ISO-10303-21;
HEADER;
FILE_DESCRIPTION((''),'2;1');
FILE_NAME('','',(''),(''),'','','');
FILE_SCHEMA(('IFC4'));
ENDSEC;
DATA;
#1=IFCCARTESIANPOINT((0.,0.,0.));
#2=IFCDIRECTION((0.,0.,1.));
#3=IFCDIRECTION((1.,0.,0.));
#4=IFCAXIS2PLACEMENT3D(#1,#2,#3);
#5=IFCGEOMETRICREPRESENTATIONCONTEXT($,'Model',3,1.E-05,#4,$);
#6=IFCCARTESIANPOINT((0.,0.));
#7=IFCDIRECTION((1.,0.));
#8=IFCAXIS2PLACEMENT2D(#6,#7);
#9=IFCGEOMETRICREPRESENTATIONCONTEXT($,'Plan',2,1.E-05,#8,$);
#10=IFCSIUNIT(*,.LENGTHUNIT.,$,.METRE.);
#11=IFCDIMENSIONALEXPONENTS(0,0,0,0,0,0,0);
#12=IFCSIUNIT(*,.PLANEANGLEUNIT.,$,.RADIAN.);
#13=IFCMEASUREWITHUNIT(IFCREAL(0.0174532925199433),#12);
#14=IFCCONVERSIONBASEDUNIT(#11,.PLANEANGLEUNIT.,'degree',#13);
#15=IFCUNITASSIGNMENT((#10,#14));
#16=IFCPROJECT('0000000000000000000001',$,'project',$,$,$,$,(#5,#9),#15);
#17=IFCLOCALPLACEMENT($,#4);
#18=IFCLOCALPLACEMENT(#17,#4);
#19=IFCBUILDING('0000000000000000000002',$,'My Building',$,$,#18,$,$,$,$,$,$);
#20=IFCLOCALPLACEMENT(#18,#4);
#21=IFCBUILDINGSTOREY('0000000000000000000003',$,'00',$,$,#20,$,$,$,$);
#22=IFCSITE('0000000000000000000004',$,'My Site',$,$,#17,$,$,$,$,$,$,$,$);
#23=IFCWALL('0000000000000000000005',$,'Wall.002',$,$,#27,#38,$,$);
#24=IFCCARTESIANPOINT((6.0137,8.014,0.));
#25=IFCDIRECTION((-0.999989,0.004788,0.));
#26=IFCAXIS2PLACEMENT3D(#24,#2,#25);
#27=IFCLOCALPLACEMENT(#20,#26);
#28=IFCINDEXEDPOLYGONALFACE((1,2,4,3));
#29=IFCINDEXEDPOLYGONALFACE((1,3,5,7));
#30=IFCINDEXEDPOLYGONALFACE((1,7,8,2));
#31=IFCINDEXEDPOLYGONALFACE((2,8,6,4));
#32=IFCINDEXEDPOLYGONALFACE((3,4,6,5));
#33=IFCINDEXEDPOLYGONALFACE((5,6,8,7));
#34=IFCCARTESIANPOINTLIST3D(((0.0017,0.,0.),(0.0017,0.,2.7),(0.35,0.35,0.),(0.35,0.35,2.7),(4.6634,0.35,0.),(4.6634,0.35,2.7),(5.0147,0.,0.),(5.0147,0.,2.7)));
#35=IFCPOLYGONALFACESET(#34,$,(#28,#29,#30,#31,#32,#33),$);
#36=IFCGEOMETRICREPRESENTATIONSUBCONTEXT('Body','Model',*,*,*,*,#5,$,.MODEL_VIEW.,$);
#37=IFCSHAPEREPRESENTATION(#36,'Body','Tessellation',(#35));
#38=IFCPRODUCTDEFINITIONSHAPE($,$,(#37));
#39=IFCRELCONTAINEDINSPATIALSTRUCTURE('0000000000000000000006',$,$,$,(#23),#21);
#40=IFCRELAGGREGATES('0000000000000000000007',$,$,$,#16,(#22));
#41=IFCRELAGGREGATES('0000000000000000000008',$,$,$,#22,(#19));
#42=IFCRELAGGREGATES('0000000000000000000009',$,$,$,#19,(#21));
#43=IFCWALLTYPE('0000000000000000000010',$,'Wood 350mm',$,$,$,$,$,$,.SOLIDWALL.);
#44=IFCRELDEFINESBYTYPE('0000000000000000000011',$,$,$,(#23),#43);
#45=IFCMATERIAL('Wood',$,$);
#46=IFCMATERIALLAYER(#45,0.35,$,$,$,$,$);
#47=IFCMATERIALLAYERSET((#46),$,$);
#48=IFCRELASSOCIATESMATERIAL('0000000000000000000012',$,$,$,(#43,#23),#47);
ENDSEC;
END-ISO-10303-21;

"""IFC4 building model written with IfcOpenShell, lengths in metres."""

from ifc_helpers import new_model, entity, si_unit, converted_unit, frame, origin_with_axes, origin_2d_with_axis, place, context, subcontext, project, spatial, indexed_curve, outline, extrude, clip, halfspace, material, layer, layer_set, layer_usage, type_object, element, save


model = new_model("IFC4")

# Units and contexts
model_context = context("Model", 3, precision=1e-05, world=origin_with_axes())
plan_context = context("Plan", 2, precision=1e-05, world=origin_2d_with_axis())
body_context = subcontext(model_context, "Body", "Model", "MODEL_VIEW")
ifc_project = project(units=[si_unit("LENGTHUNIT", "METRE"), converted_unit("PLANEANGLEUNIT", "degree", entity("IfcReal", 0.0174532925199433), si_unit("PLANEANGLEUNIT", "RADIAN"), dimensions=[0, 0, 0, 0, 0, 0, 0])], contexts=[model_context, plan_context])

# Site, building, storey
site_placement = place(None, origin_with_axes())
site = spatial("IfcSite", under=ifc_project, at=site_placement, Name="My Site")
building_placement = place(site_placement, origin_with_axes())
building = spatial("IfcBuilding", under=site, at=building_placement, Name="My Building")
storey_placement = place(building_placement, origin_with_axes())
storey = spatial("IfcBuildingStorey", under=building, at=storey_placement, Name="00")

# Shared definitions
ifc_material_1 = material(Name="Wood")

# Wall
ifc_layer_1 = layer(ifc_material_1, 0.35)
ifc_layer_set_1 = layer_set([ifc_layer_1])
wall_type = type_object("IfcWallType", Name="Wood 350mm", PredefinedType="SOLIDWALL", material=ifc_layer_set_1)
ifc_layer_usage_1 = layer_usage(ifc_layer_set_1, "AXIS2", "POSITIVE", 0.0)
wall_1_placement = place(storey_placement, frame((6.0137, 8.014, 0.0), z_axis=(0.0, 0.0, 1.0), x_axis=(-0.999989, 0.004788, 0.0)))
element("IfcWall", 1, at=wall_1_placement, inside=storey, type_object=wall_type, material=ifc_layer_usage_1, Name="Wall.002", context=body_context, shape_type="Clipping", body=[
    clip(clip(extrude(outline(indexed_curve([(0.0, 0.0), (0.0, 0.35), (5.0147, 0.35), (5.0147, 0.0), (0.0, 0.0)], self_intersect=False)), origin_with_axes(), (0.0, 0.0, 1.0), 2.7), halfspace(frame((0.0017, 0.0, 0.0), z_axis=(-0.708796, 0.705414, 0.0), x_axis=(0.705414, 0.708796, 0.0)), False)), halfspace(frame((5.0147, 0.0, 0.0), z_axis=(0.705765, 0.708447, 0.0), x_axis=(0.708446, -0.705765, 0.0)), False)),
])

save(model, "model.ifc")
